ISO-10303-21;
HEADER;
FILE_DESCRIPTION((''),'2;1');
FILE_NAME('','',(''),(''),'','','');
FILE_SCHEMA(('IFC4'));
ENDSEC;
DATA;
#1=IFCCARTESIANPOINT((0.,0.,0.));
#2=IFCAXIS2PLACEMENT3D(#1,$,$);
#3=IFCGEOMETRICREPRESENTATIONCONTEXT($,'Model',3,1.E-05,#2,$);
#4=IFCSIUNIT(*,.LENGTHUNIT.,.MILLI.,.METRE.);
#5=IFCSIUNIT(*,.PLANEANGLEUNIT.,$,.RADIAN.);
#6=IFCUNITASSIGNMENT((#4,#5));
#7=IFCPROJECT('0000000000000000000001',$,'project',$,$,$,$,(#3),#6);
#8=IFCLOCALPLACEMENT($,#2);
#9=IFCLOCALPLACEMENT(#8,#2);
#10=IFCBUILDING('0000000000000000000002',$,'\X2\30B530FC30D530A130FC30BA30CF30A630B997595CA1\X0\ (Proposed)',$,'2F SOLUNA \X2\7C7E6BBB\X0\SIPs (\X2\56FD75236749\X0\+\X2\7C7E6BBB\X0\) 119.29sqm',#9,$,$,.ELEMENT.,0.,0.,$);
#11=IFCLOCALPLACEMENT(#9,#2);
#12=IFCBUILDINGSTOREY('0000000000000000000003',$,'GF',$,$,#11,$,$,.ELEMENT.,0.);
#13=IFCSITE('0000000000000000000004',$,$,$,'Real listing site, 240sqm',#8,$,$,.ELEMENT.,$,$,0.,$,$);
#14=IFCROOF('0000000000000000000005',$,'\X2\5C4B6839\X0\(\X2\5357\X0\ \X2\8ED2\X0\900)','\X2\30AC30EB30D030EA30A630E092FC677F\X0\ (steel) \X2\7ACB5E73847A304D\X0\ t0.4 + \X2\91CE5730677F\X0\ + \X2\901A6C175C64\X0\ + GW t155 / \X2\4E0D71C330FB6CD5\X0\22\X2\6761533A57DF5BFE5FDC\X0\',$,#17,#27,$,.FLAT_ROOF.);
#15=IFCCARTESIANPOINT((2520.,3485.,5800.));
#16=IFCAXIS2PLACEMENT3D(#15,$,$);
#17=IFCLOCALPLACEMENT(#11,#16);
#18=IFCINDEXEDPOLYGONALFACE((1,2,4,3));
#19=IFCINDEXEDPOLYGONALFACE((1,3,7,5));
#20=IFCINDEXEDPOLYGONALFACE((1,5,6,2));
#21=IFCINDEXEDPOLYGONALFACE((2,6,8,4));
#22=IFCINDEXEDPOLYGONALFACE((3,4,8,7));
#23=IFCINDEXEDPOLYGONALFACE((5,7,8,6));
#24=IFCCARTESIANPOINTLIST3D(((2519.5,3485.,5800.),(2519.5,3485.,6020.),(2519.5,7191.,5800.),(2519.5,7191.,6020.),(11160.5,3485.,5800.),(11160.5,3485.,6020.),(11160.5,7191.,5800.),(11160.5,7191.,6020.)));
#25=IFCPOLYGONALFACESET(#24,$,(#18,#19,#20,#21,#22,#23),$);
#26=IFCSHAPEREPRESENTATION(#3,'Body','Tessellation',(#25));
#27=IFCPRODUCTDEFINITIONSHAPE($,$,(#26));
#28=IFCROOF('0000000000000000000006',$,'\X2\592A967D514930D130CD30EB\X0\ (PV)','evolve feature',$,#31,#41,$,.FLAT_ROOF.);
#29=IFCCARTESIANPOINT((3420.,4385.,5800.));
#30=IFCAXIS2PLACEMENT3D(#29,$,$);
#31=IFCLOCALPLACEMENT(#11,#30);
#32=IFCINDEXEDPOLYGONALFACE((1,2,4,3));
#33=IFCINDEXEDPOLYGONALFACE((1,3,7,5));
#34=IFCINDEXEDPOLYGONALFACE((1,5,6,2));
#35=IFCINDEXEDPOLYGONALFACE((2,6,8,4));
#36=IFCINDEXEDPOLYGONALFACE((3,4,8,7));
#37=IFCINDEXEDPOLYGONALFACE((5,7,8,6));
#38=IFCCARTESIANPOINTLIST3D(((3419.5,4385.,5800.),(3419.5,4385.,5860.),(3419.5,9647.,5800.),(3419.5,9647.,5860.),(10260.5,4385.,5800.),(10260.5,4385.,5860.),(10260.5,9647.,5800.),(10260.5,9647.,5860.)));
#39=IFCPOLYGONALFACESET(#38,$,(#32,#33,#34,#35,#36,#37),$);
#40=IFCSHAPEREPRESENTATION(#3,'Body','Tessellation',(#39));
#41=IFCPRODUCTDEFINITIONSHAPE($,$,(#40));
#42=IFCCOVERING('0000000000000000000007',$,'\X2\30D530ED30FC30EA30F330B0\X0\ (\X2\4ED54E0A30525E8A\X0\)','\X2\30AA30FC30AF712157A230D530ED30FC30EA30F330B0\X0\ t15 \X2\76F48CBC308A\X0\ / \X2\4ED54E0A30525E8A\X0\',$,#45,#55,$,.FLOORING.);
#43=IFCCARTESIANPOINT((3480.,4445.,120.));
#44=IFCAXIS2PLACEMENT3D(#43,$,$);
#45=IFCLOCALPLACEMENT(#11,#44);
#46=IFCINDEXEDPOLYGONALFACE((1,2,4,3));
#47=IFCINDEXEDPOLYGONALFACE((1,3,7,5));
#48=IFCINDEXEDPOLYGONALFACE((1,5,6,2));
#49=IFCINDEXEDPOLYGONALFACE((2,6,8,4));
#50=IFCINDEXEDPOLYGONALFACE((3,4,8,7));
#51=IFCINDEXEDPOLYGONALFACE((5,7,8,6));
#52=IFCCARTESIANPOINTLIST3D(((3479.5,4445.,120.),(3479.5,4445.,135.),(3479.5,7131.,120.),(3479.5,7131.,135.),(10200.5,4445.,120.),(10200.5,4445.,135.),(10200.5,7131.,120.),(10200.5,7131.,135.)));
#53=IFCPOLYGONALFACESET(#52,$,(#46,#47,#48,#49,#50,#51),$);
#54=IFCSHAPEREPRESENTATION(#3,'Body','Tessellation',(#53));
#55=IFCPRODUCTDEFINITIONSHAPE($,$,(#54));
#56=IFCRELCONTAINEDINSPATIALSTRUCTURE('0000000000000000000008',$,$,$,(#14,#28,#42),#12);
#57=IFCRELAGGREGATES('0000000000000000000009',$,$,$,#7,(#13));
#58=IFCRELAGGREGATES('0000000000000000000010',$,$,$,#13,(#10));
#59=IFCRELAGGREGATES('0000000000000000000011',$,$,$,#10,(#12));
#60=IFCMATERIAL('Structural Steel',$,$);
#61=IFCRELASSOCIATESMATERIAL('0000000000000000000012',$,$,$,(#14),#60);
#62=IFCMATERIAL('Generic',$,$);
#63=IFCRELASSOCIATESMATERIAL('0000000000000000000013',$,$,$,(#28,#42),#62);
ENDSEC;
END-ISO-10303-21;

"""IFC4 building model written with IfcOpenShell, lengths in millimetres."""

from ifc_helpers import new_model, si_unit, frame, frame_2d, origin, place, context, project, spatial, rectangle, extrude, material, element, save


model = new_model("IFC4")

# Units and contexts
model_context = context("Model", 3, precision=1e-05, world=origin())
ifc_project = project(units=[si_unit("LENGTHUNIT", "METRE", prefix="MILLI"), si_unit("PLANEANGLEUNIT", "RADIAN")], contexts=[model_context])

# Site, building, storey
site_placement = place(None, origin())
site = spatial("IfcSite", under=ifc_project, at=site_placement, ObjectType="Real listing site, 240sqm", CompositionType="ELEMENT", RefElevation=0.0)
building_placement = place(site_placement, origin())
building = spatial("IfcBuilding", under=site, at=building_placement, Name="サーファーズハウス静岡 (Proposed)", ObjectType="2F SOLUNA 籾殻SIPs (国産杉+籾殻) 119.29sqm", CompositionType="ELEMENT", ElevationOfRefHeight=0.0, ElevationOfTerrain=0.0)
storey_placement = place(building_placement, origin())
storey = spatial("IfcBuildingStorey", under=building, at=storey_placement, Name="GF", CompositionType="ELEMENT", Elevation=0.0)

# Shared definitions
ifc_material_1 = material(Name="Generic")

# Roofs
ifc_material_2 = material(Name="Structural Steel")
roof_1_placement = place(storey_placement, frame((2520.0, 3485.0, 5800.0)))
element("IfcRoof", 1, at=roof_1_placement, inside=storey, material=ifc_material_2, Name="屋根(南 軒900)", Description="ガルバリウム鋼板 (steel) 立平葺き t0.4 + 野地板 + 通気層 + GW t155 / 不燃・法22条区域対応", PredefinedType="FLAT_ROOF", context=model_context, shape_type="SweptSolid", body=[
    extrude(rectangle(XDim=8641.0, YDim=3706.0, at=frame_2d((4320.0, 1853.0))), frame((2520.0, 3485.0, 5800.0)), (0.0, 0.0, 1.0), 220.0),
])
roof_2_placement = place(storey_placement, frame((3420.0, 4385.0, 5800.0)))
element("IfcRoof", 2, at=roof_2_placement, inside=storey, material=ifc_material_1, Name="太陽光パネル (PV)", Description="evolve feature", PredefinedType="FLAT_ROOF", context=model_context, shape_type="SweptSolid", body=[
    extrude(rectangle(XDim=6841.0, YDim=5262.0, at=frame_2d((3420.0, 2631.0))), frame((3420.0, 4385.0, 5800.0)), (0.0, 0.0, 1.0), 60.0),
])

# Covering
covering_placement = place(storey_placement, frame((3480.0, 4445.0, 120.0)))
element("IfcCovering", 3, at=covering_placement, inside=storey, material=ifc_material_1, Name="フローリング (仕上げ床)", Description="オーク無垢フローリング t15 直貼り / 仕上げ床", PredefinedType="FLOORING", context=model_context, shape_type="SweptSolid", body=[
    extrude(rectangle(XDim=6721.0, YDim=2686.0, at=frame_2d((3360.0, 1343.0))), frame((3480.0, 4445.0, 120.0)), (0.0, 0.0, 1.0), 15.0),
])

save(model, "model.ifc")
